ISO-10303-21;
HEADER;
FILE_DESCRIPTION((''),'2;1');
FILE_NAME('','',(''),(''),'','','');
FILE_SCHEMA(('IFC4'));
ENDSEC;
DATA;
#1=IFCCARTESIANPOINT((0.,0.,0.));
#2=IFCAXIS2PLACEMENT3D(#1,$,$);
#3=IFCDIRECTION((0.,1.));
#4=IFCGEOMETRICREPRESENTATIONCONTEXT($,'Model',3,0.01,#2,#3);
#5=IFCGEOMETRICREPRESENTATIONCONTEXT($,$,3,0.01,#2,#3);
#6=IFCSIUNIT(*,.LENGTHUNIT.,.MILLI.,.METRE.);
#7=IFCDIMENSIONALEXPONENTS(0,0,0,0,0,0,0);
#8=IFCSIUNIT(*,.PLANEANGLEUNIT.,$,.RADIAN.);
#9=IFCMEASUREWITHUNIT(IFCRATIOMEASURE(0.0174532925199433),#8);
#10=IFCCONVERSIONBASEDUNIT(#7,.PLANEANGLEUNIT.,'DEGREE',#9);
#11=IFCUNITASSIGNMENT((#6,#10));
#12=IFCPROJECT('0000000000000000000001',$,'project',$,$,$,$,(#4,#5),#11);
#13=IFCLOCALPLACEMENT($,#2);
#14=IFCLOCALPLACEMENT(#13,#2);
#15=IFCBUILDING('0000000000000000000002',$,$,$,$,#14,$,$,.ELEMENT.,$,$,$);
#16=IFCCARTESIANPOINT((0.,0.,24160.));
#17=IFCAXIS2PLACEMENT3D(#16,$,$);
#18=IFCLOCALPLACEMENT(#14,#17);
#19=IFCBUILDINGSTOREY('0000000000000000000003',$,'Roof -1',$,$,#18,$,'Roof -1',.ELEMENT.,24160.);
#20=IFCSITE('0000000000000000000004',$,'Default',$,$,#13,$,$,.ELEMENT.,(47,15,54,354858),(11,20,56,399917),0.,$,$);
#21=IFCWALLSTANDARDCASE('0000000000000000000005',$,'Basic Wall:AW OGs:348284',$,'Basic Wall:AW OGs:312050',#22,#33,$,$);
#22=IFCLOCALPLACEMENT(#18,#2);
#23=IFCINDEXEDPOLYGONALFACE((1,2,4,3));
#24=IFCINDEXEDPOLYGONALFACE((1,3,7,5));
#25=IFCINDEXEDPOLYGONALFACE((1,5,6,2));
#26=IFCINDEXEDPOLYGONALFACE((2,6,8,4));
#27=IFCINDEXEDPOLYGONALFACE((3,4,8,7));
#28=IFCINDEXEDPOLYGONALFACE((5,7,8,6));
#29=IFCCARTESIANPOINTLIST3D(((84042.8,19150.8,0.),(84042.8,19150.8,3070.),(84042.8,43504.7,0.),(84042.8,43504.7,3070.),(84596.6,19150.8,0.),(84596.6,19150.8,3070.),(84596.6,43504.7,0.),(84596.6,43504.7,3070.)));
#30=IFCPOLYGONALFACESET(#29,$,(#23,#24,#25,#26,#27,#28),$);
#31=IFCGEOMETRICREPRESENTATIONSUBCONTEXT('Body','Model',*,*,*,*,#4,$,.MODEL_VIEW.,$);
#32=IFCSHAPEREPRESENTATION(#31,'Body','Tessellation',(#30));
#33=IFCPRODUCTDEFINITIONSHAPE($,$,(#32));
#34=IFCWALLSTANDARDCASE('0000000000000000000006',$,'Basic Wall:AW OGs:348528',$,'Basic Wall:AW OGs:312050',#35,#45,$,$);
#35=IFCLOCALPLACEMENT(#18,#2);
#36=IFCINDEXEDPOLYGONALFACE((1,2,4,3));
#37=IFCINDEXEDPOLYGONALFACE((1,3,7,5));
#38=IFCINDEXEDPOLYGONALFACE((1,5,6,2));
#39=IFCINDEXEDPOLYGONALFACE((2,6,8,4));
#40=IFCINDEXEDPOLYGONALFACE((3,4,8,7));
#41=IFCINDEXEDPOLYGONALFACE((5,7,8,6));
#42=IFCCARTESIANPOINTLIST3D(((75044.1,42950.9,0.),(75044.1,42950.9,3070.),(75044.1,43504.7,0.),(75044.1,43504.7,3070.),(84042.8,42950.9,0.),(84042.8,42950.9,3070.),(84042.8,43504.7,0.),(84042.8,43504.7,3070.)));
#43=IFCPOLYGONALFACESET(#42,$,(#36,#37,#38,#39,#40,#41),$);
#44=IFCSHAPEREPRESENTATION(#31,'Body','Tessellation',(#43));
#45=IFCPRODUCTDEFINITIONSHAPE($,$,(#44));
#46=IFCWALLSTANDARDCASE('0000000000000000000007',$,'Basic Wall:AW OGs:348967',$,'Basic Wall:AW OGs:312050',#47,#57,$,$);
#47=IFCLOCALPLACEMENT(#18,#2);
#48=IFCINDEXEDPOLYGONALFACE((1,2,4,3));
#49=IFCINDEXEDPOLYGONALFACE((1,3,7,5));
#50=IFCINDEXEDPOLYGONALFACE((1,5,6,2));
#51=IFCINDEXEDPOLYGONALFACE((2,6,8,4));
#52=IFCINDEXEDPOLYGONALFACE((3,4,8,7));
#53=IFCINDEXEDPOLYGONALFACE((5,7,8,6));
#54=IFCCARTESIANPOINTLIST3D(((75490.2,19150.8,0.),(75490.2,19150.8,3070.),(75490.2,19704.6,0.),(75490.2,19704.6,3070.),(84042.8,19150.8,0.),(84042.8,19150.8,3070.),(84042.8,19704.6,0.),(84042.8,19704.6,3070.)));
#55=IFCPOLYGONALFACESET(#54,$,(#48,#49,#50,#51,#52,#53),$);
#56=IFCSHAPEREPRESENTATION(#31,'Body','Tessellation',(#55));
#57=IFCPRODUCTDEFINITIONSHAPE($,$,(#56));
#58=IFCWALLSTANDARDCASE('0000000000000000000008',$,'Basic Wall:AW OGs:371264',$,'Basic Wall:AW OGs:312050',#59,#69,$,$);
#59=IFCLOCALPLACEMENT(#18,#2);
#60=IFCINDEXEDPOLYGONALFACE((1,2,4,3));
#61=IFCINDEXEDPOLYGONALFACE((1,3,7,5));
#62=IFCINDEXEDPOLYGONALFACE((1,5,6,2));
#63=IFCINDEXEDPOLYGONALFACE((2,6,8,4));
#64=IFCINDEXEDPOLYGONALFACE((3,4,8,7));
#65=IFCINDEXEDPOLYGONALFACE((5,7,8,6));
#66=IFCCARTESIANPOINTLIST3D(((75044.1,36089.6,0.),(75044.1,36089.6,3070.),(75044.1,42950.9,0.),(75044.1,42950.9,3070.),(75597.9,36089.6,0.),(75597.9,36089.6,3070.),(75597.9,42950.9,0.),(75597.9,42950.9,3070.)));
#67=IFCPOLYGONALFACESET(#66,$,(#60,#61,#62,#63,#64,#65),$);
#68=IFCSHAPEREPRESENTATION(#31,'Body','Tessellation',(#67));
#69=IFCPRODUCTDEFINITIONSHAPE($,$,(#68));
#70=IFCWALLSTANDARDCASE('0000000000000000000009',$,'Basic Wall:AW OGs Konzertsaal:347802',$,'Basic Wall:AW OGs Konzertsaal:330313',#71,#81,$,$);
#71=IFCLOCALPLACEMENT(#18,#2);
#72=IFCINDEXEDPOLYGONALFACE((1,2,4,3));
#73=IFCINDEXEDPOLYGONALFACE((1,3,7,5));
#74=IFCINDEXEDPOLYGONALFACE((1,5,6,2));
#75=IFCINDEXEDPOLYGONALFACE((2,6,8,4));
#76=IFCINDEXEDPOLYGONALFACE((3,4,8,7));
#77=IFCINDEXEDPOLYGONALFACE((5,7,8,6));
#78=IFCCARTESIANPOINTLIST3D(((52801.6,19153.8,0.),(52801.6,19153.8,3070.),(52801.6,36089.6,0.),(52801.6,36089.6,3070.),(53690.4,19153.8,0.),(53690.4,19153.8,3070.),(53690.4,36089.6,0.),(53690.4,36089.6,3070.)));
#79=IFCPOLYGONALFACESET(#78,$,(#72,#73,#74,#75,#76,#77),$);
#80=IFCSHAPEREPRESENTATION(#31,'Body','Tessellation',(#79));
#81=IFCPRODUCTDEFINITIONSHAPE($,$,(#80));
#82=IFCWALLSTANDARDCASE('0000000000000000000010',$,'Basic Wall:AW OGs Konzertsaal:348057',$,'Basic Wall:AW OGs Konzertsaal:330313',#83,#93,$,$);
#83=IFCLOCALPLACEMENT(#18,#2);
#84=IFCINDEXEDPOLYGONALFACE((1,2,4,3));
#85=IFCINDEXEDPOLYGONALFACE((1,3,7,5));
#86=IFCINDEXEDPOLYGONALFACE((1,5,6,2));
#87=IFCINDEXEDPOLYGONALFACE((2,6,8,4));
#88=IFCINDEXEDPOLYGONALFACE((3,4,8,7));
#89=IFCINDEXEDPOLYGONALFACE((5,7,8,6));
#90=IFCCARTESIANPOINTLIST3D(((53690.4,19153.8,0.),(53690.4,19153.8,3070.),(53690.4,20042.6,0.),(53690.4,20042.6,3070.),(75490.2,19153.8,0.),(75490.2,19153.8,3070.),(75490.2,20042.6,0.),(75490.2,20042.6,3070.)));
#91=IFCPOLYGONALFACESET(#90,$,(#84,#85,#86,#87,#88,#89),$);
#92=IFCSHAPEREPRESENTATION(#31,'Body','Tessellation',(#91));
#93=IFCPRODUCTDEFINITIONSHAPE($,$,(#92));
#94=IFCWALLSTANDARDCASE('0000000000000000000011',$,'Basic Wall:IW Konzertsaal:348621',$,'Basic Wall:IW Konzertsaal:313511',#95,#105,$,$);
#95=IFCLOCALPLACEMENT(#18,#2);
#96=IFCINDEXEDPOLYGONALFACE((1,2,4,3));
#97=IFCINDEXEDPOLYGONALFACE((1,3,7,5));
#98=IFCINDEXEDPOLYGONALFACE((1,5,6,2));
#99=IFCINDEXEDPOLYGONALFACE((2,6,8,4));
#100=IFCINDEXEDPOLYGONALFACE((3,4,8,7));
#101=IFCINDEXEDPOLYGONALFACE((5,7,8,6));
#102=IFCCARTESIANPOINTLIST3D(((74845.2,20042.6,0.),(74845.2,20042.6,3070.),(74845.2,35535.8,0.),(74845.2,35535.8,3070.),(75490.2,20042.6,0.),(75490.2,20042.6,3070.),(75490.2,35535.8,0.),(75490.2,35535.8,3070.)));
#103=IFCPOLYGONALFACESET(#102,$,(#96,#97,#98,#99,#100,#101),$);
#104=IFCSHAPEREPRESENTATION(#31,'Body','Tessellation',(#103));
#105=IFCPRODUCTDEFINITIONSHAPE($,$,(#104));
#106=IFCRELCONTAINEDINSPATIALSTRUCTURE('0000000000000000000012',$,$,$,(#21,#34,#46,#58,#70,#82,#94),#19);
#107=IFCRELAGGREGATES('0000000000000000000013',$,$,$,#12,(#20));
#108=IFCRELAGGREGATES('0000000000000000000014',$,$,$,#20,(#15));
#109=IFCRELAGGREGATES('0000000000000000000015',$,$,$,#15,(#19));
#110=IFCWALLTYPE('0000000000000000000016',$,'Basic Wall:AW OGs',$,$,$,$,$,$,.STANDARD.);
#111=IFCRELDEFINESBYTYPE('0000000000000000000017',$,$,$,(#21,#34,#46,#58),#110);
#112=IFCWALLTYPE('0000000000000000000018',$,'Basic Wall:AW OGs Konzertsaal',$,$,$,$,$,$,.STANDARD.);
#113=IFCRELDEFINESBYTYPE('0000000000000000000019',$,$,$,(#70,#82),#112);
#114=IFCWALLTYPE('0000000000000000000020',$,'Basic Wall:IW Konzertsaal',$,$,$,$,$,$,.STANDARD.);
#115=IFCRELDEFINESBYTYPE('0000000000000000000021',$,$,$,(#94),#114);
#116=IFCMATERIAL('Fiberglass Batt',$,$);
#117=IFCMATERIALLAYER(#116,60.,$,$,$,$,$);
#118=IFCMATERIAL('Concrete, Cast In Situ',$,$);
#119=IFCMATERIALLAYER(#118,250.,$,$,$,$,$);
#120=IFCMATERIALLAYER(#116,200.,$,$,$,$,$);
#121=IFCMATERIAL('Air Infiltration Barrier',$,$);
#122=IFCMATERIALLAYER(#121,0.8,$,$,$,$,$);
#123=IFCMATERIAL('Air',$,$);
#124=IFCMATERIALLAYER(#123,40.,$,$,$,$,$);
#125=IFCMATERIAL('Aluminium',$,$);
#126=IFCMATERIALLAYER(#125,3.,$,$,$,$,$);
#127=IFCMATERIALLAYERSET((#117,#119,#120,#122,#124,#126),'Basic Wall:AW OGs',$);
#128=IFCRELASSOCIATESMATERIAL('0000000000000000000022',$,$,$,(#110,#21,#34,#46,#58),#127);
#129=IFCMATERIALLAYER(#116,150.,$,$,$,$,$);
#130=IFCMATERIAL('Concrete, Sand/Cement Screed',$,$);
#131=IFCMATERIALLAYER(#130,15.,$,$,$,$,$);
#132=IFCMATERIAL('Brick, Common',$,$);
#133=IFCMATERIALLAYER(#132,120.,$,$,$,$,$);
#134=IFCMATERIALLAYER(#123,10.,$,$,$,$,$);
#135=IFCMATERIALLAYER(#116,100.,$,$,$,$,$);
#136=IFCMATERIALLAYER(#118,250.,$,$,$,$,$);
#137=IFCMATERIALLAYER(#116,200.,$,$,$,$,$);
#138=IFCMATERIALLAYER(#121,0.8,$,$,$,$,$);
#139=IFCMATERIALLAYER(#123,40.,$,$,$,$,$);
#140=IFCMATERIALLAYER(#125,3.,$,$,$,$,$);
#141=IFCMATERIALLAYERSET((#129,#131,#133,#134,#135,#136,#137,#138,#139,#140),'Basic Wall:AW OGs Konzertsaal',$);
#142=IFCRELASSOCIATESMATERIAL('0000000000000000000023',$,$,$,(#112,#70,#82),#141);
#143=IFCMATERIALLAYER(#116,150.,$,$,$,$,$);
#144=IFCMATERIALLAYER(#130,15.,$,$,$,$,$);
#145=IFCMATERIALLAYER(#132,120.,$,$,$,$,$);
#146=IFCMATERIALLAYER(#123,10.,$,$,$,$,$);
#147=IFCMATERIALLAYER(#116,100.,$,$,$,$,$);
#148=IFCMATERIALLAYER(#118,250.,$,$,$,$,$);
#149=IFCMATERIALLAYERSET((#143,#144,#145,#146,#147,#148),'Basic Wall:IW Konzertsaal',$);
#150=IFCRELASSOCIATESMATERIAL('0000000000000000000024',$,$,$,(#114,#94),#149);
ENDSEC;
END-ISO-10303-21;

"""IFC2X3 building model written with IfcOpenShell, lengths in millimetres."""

from ifc_helpers import new_model, entity, si_unit, converted_unit, direction, frame, frame_2d, origin, place, context, subcontext, project, spatial, rectangle, extrude, material, layer, layer_set, layer_usage, type_object, element, save


model = new_model("IFC2X3")

# Units and contexts
model_context = context("Model", 3, precision=0.01, world=origin(), true_north=direction((0.0, 1.0)))
context_of_model = context(None, 3, precision=0.01, world=origin(), true_north=direction((0.0, 1.0)))
body_context = subcontext(model_context, "Body", "Model", "MODEL_VIEW")
ifc_project = project(units=[si_unit("LENGTHUNIT", "METRE", prefix="MILLI"), converted_unit("PLANEANGLEUNIT", "DEGREE", entity("IfcRatioMeasure", 0.0174532925199433), si_unit("PLANEANGLEUNIT", "RADIAN"), dimensions=[0, 0, 0, 0, 0, 0, 0])], contexts=[model_context, context_of_model])

# Site, building, storey
site_placement = place(None, origin())
site = spatial("IfcSite", under=ifc_project, at=site_placement, Name="Default", CompositionType="ELEMENT", RefLatitude=(47, 15, 54, 354858), RefLongitude=(11, 20, 56, 399917), RefElevation=0.0)
building_placement = place(site_placement, origin())
building = spatial("IfcBuilding", under=site, at=building_placement, CompositionType="ELEMENT")
storey_placement = place(building_placement, frame((0.0, 0.0, 24160.0)))
storey = spatial("IfcBuildingStorey", under=building, at=storey_placement, Name="Roof -1", LongName="Roof -1", CompositionType="ELEMENT", Elevation=24160.0)

# Walls
ifc_material_1 = material(Name="Fiberglass Batt")
ifc_layer_1 = layer(ifc_material_1, 60.0)
ifc_material_2 = material(Name="Concrete, Cast In Situ")
ifc_layer_2 = layer(ifc_material_2, 250.0)
ifc_layer_3 = layer(ifc_material_1, 200.0)
ifc_material_3 = material(Name="Air Infiltration Barrier")
ifc_layer_4 = layer(ifc_material_3, 0.8)
ifc_material_4 = material(Name="Air")
ifc_layer_5 = layer(ifc_material_4, 40.0)
ifc_material_5 = material(Name="Aluminium")
ifc_layer_6 = layer(ifc_material_5, 3.0)
ifc_layer_set_1 = layer_set([ifc_layer_1, ifc_layer_2, ifc_layer_3, ifc_layer_4, ifc_layer_5, ifc_layer_6], Name="Basic Wall:AW OGs")
ifc_layer_usage_1 = layer_usage(ifc_layer_set_1, "AXIS2", "NEGATIVE", 276.9)
wall_type_1 = type_object("IfcWallType", Name="Basic Wall:AW OGs", PredefinedType="STANDARD", material=ifc_layer_set_1)
wall_1_placement = place(storey_placement, frame((84319.7, 19150.8, 0.0), z_axis=(0.0, 0.0, 1.0), x_axis=(0.0, 1.0, 0.0)))
element("IfcWallStandardCase", 1, at=wall_1_placement, inside=storey, type_object=wall_type_1, material=ifc_layer_usage_1, Name="Basic Wall:AW OGs:348284", ObjectType="Basic Wall:AW OGs:312050", context=body_context, shape_type="SweptSolid", body=[
    extrude(rectangle(XDim=24353.8, YDim=553.8, at=frame_2d((12176.9, 0.0), x_axis=(-1.0, 0.0))), origin(), (0.0, 0.0, 1.0), 3070.0),
])
ifc_layer_usage_2 = layer_usage(ifc_layer_set_1, "AXIS2", "NEGATIVE", 276.9)
wall_2_placement = place(storey_placement, frame((84042.8, 43227.8, 0.0), z_axis=(0.0, 0.0, 1.0), x_axis=(-1.0, 0.0, 0.0)))
element("IfcWallStandardCase", 2, at=wall_2_placement, inside=storey, type_object=wall_type_1, material=ifc_layer_usage_2, Name="Basic Wall:AW OGs:348528", ObjectType="Basic Wall:AW OGs:312050", context=body_context, shape_type="SweptSolid", body=[
    extrude(rectangle(XDim=8998.7, YDim=553.8, at=frame_2d((4499.4, 0.0), x_axis=(-1.0, 0.0))), origin(), (0.0, 0.0, 1.0), 3070.0),
])
ifc_layer_usage_3 = layer_usage(ifc_layer_set_1, "AXIS2", "POSITIVE", -276.9)
wall_3_placement = place(storey_placement, frame((84042.8, 19427.7, 0.0), z_axis=(0.0, 0.0, 1.0), x_axis=(-1.0, 0.0, 0.0)))
element("IfcWallStandardCase", 3, at=wall_3_placement, inside=storey, type_object=wall_type_1, material=ifc_layer_usage_3, Name="Basic Wall:AW OGs:348967", ObjectType="Basic Wall:AW OGs:312050", context=body_context, shape_type="SweptSolid", body=[
    extrude(rectangle(XDim=8552.6, YDim=553.8, at=frame_2d((4276.3, 0.0), x_axis=(-1.0, 0.0))), origin(), (0.0, 0.0, 1.0), 3070.0),
])

# Walls
ifc_layer_usage_4 = layer_usage(ifc_layer_set_1, "AXIS2", "NEGATIVE", 276.9)
wall_4_placement = place(storey_placement, frame((75321.0, 42950.9, 0.0), z_axis=(0.0, 0.0, 1.0), x_axis=(0.0, -1.0, 0.0)))
element("IfcWallStandardCase", 4, at=wall_4_placement, inside=storey, type_object=wall_type_1, material=ifc_layer_usage_4, Name="Basic Wall:AW OGs:371264", ObjectType="Basic Wall:AW OGs:312050", context=body_context, shape_type="SweptSolid", body=[
    extrude(rectangle(XDim=6861.2, YDim=553.8, at=frame_2d((3430.6, 0.0), x_axis=(-1.0, 0.0))), origin(), (0.0, 0.0, 1.0), 3070.0),
])
ifc_layer_7 = layer(ifc_material_1, 150.0)
ifc_material_6 = material(Name="Concrete, Sand/Cement Screed")
ifc_layer_8 = layer(ifc_material_6, 15.0)
ifc_material_7 = material(Name="Brick, Common")
ifc_layer_9 = layer(ifc_material_7, 120.0)
ifc_layer_10 = layer(ifc_material_4, 10.0)
ifc_layer_11 = layer(ifc_material_1, 100.0)
ifc_layer_12 = layer(ifc_material_2, 250.0)
ifc_layer_13 = layer(ifc_material_1, 200.0)
ifc_layer_14 = layer(ifc_material_3, 0.8)
ifc_layer_15 = layer(ifc_material_4, 40.0)
ifc_layer_16 = layer(ifc_material_5, 3.0)
ifc_layer_set_2 = layer_set([ifc_layer_7, ifc_layer_8, ifc_layer_9, ifc_layer_10, ifc_layer_11, ifc_layer_12, ifc_layer_13, ifc_layer_14, ifc_layer_15, ifc_layer_16], Name="Basic Wall:AW OGs Konzertsaal")
ifc_layer_usage_5 = layer_usage(ifc_layer_set_2, "AXIS2", "NEGATIVE", 444.4)
wall_type_2 = type_object("IfcWallType", Name="Basic Wall:AW OGs Konzertsaal", PredefinedType="STANDARD", material=ifc_layer_set_2)
wall_5_placement = place(storey_placement, frame((53246.0, 36089.6, 0.0), z_axis=(0.0, 0.0, 1.0), x_axis=(0.0, -1.0, 0.0)))
element("IfcWallStandardCase", 5, at=wall_5_placement, inside=storey, type_object=wall_type_2, material=ifc_layer_usage_5, Name="Basic Wall:AW OGs Konzertsaal:347802", ObjectType="Basic Wall:AW OGs Konzertsaal:330313", context=body_context, shape_type="SweptSolid", body=[
    extrude(rectangle(XDim=16935.8, YDim=888.8, at=frame_2d((8467.9, 0.0), x_axis=(-1.0, 0.0))), origin(), (0.0, 0.0, 1.0), 3070.0),
])
ifc_layer_usage_6 = layer_usage(ifc_layer_set_2, "AXIS2", "NEGATIVE", 444.4)
wall_6_placement = place(storey_placement, frame((53690.4, 19598.2, 0.0)))
element("IfcWallStandardCase", 6, at=wall_6_placement, inside=storey, type_object=wall_type_2, material=ifc_layer_usage_6, Name="Basic Wall:AW OGs Konzertsaal:348057", ObjectType="Basic Wall:AW OGs Konzertsaal:330313", context=body_context, shape_type="SweptSolid", body=[
    extrude(rectangle(XDim=21799.8, YDim=888.8, at=frame_2d((10899.9, 0.0), x_axis=(-1.0, 0.0))), origin(), (0.0, 0.0, 1.0), 3070.0),
])
ifc_layer_17 = layer(ifc_material_1, 150.0)
ifc_layer_18 = layer(ifc_material_6, 15.0)
ifc_layer_19 = layer(ifc_material_7, 120.0)
ifc_layer_20 = layer(ifc_material_4, 10.0)
ifc_layer_21 = layer(ifc_material_1, 100.0)
ifc_layer_22 = layer(ifc_material_2, 250.0)
ifc_layer_set_3 = layer_set([ifc_layer_17, ifc_layer_18, ifc_layer_19, ifc_layer_20, ifc_layer_21, ifc_layer_22], Name="Basic Wall:IW Konzertsaal")
ifc_layer_usage_7 = layer_usage(ifc_layer_set_3, "AXIS2", "NEGATIVE", 322.5)
wall_type_3 = type_object("IfcWallType", Name="Basic Wall:IW Konzertsaal", PredefinedType="STANDARD", material=ifc_layer_set_3)
wall_7_placement = place(storey_placement, frame((75167.7, 20042.6, 0.0), z_axis=(0.0, 0.0, 1.0), x_axis=(0.0, 1.0, 0.0)))
element("IfcWallStandardCase", 7, at=wall_7_placement, inside=storey, type_object=wall_type_3, material=ifc_layer_usage_7, Name="Basic Wall:IW Konzertsaal:348621", ObjectType="Basic Wall:IW Konzertsaal:313511", context=body_context, shape_type="SweptSolid", body=[
    extrude(rectangle(XDim=15493.2, YDim=645.0, at=frame_2d((7746.6, 0.0), x_axis=(-1.0, 0.0))), origin(), (0.0, 0.0, 1.0), 3070.0),
])

save(model, "model.ifc")
